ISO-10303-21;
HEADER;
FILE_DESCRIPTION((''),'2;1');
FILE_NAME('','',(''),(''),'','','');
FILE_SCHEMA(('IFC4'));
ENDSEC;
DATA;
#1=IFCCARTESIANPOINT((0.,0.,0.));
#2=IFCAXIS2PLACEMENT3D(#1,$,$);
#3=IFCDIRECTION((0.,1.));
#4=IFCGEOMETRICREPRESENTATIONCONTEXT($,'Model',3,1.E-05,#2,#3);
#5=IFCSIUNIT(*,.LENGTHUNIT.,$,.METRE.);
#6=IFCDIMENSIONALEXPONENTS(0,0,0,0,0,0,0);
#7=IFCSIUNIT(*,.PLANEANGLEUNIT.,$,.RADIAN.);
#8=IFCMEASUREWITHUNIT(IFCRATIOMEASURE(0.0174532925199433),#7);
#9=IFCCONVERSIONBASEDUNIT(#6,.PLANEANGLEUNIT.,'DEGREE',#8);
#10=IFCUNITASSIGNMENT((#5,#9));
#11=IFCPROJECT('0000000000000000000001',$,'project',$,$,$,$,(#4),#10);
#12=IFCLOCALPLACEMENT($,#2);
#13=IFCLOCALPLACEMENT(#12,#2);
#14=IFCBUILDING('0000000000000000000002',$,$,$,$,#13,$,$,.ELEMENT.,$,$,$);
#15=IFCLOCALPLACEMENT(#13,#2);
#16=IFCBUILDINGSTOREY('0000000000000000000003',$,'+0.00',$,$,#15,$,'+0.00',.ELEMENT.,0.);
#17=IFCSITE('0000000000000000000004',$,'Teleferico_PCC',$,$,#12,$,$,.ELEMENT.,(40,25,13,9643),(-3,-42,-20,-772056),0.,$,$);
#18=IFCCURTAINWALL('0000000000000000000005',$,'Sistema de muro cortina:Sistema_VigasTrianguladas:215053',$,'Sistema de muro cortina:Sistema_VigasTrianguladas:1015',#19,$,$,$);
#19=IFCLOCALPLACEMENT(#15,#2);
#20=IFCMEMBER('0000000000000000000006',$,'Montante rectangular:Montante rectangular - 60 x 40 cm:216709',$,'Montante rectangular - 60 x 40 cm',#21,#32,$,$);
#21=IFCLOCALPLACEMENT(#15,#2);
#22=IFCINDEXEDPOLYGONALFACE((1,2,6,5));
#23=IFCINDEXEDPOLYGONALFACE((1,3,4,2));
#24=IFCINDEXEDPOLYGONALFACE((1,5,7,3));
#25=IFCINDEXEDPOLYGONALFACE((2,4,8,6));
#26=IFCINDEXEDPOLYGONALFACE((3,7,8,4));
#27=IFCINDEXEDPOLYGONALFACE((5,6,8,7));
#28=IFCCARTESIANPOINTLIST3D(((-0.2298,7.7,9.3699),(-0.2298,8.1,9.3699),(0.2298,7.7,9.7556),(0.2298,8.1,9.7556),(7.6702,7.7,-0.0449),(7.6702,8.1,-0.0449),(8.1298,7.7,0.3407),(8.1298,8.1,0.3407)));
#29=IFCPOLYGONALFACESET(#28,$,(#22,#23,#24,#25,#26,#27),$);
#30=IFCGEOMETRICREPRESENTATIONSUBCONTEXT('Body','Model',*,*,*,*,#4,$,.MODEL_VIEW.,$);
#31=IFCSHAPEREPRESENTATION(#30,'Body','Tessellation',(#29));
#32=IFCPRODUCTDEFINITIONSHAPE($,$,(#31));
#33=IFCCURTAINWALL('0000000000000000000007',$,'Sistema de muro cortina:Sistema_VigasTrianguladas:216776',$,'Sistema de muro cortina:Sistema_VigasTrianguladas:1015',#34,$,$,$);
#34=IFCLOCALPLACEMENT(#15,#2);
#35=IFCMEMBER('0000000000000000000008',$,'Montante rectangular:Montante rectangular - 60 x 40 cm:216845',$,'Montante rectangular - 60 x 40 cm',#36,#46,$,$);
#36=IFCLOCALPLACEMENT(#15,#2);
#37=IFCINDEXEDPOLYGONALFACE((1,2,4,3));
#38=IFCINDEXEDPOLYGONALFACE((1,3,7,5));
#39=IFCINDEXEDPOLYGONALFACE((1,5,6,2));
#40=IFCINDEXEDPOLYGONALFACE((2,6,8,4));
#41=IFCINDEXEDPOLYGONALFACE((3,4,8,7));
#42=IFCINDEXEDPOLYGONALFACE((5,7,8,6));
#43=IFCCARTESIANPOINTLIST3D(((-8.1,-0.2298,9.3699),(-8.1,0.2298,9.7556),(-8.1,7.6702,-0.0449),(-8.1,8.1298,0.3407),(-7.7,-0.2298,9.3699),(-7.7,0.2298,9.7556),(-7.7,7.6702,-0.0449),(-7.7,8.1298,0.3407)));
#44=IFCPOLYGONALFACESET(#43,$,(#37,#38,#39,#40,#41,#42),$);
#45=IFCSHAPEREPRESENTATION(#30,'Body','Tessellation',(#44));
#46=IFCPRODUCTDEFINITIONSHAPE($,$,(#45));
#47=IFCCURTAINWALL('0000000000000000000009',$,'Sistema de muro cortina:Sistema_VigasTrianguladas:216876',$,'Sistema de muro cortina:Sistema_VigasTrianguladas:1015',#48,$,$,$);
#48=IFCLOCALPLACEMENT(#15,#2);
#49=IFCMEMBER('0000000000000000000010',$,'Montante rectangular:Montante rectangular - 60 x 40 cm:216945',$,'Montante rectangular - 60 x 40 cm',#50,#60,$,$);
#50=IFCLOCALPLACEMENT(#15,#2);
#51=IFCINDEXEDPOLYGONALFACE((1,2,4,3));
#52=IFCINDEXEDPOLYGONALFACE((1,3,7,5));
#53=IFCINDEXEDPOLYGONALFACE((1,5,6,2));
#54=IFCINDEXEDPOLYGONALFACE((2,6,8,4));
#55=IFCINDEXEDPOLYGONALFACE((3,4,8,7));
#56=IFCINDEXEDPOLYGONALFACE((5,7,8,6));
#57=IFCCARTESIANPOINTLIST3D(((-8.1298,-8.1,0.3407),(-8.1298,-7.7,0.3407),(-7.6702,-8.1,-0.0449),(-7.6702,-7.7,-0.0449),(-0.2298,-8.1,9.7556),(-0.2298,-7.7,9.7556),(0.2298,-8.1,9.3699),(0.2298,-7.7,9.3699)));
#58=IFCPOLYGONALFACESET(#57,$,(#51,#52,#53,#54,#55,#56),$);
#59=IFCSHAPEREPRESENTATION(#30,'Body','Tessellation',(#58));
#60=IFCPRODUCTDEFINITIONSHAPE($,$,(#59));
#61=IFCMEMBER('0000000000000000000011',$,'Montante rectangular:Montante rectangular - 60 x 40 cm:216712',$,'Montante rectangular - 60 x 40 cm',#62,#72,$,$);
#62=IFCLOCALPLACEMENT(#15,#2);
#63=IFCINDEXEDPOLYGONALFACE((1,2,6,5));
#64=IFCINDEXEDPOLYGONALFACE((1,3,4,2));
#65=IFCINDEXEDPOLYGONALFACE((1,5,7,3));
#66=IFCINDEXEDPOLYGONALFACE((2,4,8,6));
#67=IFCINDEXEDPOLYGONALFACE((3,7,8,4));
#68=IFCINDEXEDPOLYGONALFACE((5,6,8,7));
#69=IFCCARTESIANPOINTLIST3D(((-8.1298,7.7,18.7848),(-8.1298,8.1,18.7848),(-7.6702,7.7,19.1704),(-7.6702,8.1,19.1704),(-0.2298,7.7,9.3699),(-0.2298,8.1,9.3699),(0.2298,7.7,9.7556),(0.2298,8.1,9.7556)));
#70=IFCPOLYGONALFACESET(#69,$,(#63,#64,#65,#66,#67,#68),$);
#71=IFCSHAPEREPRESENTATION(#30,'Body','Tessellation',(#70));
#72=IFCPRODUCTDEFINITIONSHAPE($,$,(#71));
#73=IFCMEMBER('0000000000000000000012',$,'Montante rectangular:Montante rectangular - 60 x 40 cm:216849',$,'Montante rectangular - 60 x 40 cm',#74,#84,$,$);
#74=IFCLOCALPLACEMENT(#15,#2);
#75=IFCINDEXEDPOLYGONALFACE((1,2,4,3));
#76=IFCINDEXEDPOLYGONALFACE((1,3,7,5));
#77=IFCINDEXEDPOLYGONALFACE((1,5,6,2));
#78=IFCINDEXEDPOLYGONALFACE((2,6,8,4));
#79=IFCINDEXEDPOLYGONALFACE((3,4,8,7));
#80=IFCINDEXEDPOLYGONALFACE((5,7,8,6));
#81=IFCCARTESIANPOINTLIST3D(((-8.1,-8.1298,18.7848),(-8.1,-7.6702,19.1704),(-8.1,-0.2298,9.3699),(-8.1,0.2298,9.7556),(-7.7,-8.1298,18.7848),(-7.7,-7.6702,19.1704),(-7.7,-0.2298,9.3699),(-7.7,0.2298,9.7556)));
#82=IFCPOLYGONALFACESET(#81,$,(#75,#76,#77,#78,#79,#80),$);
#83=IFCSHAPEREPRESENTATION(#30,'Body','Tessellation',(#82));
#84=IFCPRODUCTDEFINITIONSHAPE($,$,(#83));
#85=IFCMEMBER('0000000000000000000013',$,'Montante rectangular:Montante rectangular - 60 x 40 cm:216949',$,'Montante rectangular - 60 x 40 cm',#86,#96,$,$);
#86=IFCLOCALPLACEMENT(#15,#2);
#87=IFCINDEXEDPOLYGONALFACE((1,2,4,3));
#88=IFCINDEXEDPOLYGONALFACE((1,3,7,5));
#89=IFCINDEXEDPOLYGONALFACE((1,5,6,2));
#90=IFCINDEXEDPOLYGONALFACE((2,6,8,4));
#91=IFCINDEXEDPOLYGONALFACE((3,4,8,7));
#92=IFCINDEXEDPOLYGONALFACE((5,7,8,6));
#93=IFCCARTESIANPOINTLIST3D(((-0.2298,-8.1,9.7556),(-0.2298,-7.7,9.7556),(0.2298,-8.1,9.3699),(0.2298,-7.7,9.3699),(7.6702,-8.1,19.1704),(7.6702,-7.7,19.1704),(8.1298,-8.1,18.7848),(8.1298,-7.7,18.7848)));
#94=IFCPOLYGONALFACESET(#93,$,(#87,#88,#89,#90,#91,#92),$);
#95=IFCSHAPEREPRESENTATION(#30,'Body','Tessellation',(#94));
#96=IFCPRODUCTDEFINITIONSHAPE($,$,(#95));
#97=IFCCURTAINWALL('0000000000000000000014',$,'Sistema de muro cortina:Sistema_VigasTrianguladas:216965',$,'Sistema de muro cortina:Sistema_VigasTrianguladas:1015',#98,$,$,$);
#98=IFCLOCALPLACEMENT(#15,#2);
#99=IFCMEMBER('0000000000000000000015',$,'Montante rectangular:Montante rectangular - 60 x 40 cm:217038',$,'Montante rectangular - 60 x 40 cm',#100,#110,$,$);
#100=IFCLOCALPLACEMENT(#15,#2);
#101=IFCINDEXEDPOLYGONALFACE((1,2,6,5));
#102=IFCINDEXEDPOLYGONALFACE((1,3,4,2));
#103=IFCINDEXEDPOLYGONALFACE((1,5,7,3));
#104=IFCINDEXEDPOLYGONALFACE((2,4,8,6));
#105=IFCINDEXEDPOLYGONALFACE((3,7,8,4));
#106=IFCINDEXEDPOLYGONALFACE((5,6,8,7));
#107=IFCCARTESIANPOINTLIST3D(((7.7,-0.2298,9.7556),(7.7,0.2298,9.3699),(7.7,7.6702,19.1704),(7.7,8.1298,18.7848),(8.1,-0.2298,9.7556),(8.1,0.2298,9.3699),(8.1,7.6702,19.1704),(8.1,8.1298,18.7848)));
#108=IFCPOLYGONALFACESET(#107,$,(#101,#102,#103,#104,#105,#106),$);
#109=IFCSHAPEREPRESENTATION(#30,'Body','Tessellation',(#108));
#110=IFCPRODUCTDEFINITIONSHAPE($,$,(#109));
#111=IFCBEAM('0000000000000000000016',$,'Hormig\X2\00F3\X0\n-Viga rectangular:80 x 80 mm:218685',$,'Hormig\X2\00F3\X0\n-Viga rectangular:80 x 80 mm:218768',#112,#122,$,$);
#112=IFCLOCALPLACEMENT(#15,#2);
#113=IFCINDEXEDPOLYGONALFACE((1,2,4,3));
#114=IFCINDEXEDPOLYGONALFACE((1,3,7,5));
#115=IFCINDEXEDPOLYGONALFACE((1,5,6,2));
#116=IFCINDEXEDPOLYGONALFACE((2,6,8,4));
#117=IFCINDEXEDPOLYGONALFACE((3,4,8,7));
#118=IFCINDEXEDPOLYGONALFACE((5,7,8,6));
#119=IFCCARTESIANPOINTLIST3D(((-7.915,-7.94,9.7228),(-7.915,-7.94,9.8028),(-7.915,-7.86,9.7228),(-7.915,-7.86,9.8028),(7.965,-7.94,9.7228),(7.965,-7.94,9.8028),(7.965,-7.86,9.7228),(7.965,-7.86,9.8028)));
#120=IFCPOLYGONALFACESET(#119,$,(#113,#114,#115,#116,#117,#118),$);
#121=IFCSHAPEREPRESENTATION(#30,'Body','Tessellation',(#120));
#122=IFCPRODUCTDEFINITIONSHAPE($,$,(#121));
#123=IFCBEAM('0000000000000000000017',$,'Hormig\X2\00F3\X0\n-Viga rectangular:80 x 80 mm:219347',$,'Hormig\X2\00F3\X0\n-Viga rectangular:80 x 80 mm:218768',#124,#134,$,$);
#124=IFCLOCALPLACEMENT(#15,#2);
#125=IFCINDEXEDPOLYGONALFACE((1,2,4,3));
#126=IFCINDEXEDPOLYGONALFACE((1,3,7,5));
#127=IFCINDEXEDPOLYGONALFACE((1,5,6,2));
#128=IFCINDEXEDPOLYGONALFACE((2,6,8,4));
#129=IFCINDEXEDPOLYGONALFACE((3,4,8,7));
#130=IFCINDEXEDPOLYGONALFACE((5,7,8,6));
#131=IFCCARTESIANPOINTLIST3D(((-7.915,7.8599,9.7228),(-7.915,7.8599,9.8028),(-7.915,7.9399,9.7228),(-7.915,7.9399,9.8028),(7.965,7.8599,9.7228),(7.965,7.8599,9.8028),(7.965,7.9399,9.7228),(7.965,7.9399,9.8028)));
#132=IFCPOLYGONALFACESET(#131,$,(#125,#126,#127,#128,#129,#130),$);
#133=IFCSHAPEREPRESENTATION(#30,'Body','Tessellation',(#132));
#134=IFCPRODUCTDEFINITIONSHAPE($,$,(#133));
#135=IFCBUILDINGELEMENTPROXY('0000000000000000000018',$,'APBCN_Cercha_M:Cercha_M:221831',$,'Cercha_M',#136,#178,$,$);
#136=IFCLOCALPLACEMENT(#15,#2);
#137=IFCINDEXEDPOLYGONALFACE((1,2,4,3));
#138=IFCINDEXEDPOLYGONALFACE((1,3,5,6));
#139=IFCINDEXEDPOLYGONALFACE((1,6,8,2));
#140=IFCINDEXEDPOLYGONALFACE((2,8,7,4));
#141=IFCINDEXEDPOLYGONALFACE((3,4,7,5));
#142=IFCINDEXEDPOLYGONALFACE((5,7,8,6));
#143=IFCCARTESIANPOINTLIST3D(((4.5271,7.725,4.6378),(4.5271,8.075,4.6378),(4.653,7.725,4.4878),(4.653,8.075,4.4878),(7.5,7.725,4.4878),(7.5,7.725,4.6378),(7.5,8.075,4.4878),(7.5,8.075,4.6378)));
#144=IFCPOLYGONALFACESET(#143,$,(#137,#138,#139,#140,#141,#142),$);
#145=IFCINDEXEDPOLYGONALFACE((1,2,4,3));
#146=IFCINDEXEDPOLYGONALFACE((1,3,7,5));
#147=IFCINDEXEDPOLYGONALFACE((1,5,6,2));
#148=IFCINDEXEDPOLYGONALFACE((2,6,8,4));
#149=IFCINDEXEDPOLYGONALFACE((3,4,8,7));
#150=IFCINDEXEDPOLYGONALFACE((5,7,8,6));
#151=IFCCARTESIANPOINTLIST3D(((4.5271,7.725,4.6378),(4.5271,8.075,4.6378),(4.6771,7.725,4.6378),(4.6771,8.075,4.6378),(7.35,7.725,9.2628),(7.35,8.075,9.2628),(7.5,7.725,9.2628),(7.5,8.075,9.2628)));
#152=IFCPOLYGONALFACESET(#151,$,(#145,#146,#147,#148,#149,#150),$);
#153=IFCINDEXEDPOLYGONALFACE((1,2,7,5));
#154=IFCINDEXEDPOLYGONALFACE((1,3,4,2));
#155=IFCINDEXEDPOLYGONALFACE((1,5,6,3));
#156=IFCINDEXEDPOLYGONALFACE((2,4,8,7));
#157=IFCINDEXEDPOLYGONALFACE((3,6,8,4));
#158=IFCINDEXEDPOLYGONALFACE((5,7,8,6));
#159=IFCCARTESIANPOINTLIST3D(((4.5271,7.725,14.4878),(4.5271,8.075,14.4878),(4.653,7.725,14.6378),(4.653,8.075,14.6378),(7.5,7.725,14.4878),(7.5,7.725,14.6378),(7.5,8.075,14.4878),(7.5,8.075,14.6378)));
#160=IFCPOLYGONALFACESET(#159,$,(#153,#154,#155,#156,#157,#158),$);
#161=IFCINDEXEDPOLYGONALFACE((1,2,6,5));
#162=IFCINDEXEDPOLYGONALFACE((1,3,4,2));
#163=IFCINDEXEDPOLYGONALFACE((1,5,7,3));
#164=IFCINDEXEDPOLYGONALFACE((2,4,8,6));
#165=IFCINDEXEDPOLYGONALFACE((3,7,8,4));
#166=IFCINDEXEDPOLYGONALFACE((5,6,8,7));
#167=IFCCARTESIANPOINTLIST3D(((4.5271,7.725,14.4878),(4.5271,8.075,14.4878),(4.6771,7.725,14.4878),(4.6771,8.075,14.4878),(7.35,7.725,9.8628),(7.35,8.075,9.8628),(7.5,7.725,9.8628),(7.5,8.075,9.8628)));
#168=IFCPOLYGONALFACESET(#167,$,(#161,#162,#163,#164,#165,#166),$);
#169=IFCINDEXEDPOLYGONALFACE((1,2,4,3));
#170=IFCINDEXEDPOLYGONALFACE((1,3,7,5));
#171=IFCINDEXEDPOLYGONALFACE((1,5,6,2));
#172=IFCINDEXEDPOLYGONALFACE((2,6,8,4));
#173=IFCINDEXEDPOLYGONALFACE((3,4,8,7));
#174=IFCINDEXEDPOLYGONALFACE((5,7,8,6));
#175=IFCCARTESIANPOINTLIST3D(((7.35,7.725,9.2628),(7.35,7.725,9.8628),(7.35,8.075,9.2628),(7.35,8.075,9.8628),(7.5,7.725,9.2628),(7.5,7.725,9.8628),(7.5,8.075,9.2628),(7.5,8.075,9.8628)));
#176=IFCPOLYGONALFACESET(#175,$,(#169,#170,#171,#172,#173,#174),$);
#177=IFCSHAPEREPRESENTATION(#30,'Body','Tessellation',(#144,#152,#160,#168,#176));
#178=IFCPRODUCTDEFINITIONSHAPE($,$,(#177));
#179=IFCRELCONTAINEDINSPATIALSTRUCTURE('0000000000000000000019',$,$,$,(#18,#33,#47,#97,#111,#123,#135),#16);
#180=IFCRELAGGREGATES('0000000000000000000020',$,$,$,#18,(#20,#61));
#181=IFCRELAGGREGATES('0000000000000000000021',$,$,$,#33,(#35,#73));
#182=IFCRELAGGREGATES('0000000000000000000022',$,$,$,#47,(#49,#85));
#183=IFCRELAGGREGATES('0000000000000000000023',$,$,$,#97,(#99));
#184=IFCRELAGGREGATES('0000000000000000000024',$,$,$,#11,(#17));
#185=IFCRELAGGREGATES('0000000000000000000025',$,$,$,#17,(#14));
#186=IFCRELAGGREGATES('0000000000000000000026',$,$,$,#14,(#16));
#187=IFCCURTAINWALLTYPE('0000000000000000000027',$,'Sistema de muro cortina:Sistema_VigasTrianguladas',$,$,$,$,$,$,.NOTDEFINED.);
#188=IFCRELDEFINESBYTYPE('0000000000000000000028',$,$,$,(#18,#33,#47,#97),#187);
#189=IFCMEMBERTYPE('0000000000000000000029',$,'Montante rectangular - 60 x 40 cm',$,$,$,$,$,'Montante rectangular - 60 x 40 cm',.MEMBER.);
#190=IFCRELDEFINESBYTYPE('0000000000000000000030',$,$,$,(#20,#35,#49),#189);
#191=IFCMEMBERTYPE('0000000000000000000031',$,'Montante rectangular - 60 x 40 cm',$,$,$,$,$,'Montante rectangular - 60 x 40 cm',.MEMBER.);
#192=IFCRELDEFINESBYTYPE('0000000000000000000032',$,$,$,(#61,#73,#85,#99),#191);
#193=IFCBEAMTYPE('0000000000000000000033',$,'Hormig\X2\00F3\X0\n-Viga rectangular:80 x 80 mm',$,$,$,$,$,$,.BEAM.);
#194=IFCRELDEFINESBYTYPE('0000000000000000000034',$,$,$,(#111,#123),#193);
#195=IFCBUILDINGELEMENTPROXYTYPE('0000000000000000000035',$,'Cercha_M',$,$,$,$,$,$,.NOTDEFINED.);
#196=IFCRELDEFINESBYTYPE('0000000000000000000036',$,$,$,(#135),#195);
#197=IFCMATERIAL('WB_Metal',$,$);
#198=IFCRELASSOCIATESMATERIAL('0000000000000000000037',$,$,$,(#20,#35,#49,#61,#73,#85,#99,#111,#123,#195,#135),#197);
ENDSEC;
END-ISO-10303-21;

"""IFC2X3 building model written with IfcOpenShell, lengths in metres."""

from ifc_helpers import new_model, entity, si_unit, converted_unit, direction, frame, frame_2d, origin, origin_2d_with_axis, place, context, subcontext, project, spatial, polyline, rectangle, outline, extrude, source, transform, mapped, material, type_object, type_shapes, element, aggregate, save


model = new_model("IFC2X3")

# Units and contexts
model_context = context("Model", 3, precision=1e-05, world=origin(), true_north=direction((0.0, 1.0)))
body_context = subcontext(model_context, "Body", "Model", "MODEL_VIEW")
ifc_project = project(units=[si_unit("LENGTHUNIT", "METRE"), converted_unit("PLANEANGLEUNIT", "DEGREE", entity("IfcRatioMeasure", 0.0174532925199433), si_unit("PLANEANGLEUNIT", "RADIAN"), dimensions=[0, 0, 0, 0, 0, 0, 0])], contexts=[model_context])

# Site, building, storey
site_placement = place(None, origin())
site = spatial("IfcSite", under=ifc_project, at=site_placement, Name="Teleferico_PCC", CompositionType="ELEMENT", RefLatitude=(40, 25, 13, 9643), RefLongitude=(-3, -42, -20, -772056), RefElevation=0.0)
building_placement = place(site_placement, origin())
building = spatial("IfcBuilding", under=site, at=building_placement, CompositionType="ELEMENT")
storey_placement = place(building_placement, origin())
storey = spatial("IfcBuildingStorey", under=building, at=storey_placement, Name="+0.00", LongName="+0.00", CompositionType="ELEMENT", Elevation=0.0)

# Curtain walls, members
curtain_wall_type = type_object("IfcCurtainWallType", Name="Sistema de muro cortina:Sistema_VigasTrianguladas", PredefinedType="NOTDEFINED")
curtain_wall_1_placement = place(storey_placement, origin())
curtain_wall_1 = element("IfcCurtainWall", 1, at=curtain_wall_1_placement, inside=storey, type_object=curtain_wall_type, Name="Sistema de muro cortina:Sistema_VigasTrianguladas:215053", ObjectType="Sistema de muro cortina:Sistema_VigasTrianguladas:1015")
ifc_material = material(Name="WB_Metal")
member_type_1 = type_object("IfcMemberType", Name="Montante rectangular - 60 x 40 cm", ElementType="Montante rectangular - 60 x 40 cm", PredefinedType="MEMBER")
shared_shape_1 = source(origin(), body_context, "Body", "SweptSolid", [
    extrude(rectangle(XDim=0.4, YDim=0.6, at=frame_2d((0.0, 0.0), x_axis=(1.0, 0.0))), frame((0.0, 0.0, -12.2902), z_axis=(0.0, 0.0, 1.0), x_axis=(0.0, -1.0, 0.0)), (0.0, 0.0, 1.0), 12.2902),
])
type_shapes(member_type_1, [shared_shape_1])
member_1_placement = place(storey_placement, frame((0.0, 7.9, 9.5628), z_axis=(-0.642788, 0.0, 0.766044), x_axis=(0.766044, 0.0, 0.642788)))
member_1 = element("IfcMember", 2, at=member_1_placement, type_object=member_type_1, material=ifc_material, Name="Montante rectangular:Montante rectangular - 60 x 40 cm:216709", ObjectType="Montante rectangular - 60 x 40 cm", context=body_context, shape_type="MappedRepresentation", body=[
    mapped(shared_shape_1, transform((0.0, 0.0, 0.0), scale=1.0)),
])
curtain_wall_2_placement = place(storey_placement, origin())
curtain_wall_2 = element("IfcCurtainWall", 3, at=curtain_wall_2_placement, inside=storey, type_object=curtain_wall_type, Name="Sistema de muro cortina:Sistema_VigasTrianguladas:216776", ObjectType="Sistema de muro cortina:Sistema_VigasTrianguladas:1015")
member_2_placement = place(storey_placement, frame((-7.9, 0.0, 9.5628), z_axis=(0.0, -0.642788, 0.766044), x_axis=(0.0, 0.766044, 0.642788)))
member_2 = element("IfcMember", 4, at=member_2_placement, type_object=member_type_1, material=ifc_material, Name="Montante rectangular:Montante rectangular - 60 x 40 cm:216845", ObjectType="Montante rectangular - 60 x 40 cm", context=body_context, shape_type="MappedRepresentation", body=[
    mapped(shared_shape_1, transform((0.0, 0.0, 0.0), scale=1.0)),
])
curtain_wall_3_placement = place(storey_placement, origin())
curtain_wall_3 = element("IfcCurtainWall", 5, at=curtain_wall_3_placement, inside=storey, type_object=curtain_wall_type, Name="Sistema de muro cortina:Sistema_VigasTrianguladas:216876", ObjectType="Sistema de muro cortina:Sistema_VigasTrianguladas:1015")
member_3_placement = place(storey_placement, frame((0.0, -7.9, 9.5628), z_axis=(0.642788, 0.0, 0.766044), x_axis=(-0.766044, 0.0, 0.642788)))
member_3 = element("IfcMember", 6, at=member_3_placement, type_object=member_type_1, material=ifc_material, Name="Montante rectangular:Montante rectangular - 60 x 40 cm:216945", ObjectType="Montante rectangular - 60 x 40 cm", context=body_context, shape_type="MappedRepresentation", body=[
    mapped(shared_shape_1, transform((0.0, 0.0, 0.0), scale=1.0)),
])

# Members
member_type_2 = type_object("IfcMemberType", Name="Montante rectangular - 60 x 40 cm", ElementType="Montante rectangular - 60 x 40 cm", PredefinedType="MEMBER")
shared_shape_2 = source(origin(), body_context, "Body", "SweptSolid", [
    extrude(rectangle(XDim=0.4, YDim=0.6, at=origin_2d_with_axis()), frame((0.0, 0.0, -12.2902), z_axis=(0.0, 0.0, 1.0), x_axis=(0.0, -1.0, 0.0)), (0.0, 0.0, 1.0), 12.2902),
])
type_shapes(member_type_2, [shared_shape_2])
member_4_placement = place(storey_placement, frame((-7.9, 7.9, 18.9776), z_axis=(-0.642788, 0.0, 0.766044), x_axis=(0.766044, 0.0, 0.642788)))
member_4 = element("IfcMember", 7, at=member_4_placement, type_object=member_type_2, material=ifc_material, Name="Montante rectangular:Montante rectangular - 60 x 40 cm:216712", ObjectType="Montante rectangular - 60 x 40 cm", context=body_context, shape_type="MappedRepresentation", body=[
    mapped(shared_shape_2, transform((0.0, 0.0, 0.0), scale=1.0)),
])
member_5_placement = place(storey_placement, frame((-7.9, -7.9, 18.9776), z_axis=(0.0, -0.642788, 0.766044), x_axis=(0.0, 0.766044, 0.642788)))
member_5 = element("IfcMember", 8, at=member_5_placement, type_object=member_type_2, material=ifc_material, Name="Montante rectangular:Montante rectangular - 60 x 40 cm:216849", ObjectType="Montante rectangular - 60 x 40 cm", context=body_context, shape_type="MappedRepresentation", body=[
    mapped(shared_shape_2, transform((0.0, 0.0, 0.0), scale=1.0)),
])
member_6_placement = place(storey_placement, frame((7.9, -7.9, 18.9776), z_axis=(0.642788, 0.0, 0.766044), x_axis=(-0.766044, 0.0, 0.642788)))
member_6 = element("IfcMember", 9, at=member_6_placement, type_object=member_type_2, material=ifc_material, Name="Montante rectangular:Montante rectangular - 60 x 40 cm:216949", ObjectType="Montante rectangular - 60 x 40 cm", context=body_context, shape_type="MappedRepresentation", body=[
    mapped(shared_shape_2, transform((0.0, 0.0, 0.0), scale=1.0)),
])

# Curtain wall, member
curtain_wall_4_placement = place(storey_placement, origin())
curtain_wall_4 = element("IfcCurtainWall", 10, at=curtain_wall_4_placement, inside=storey, type_object=curtain_wall_type, Name="Sistema de muro cortina:Sistema_VigasTrianguladas:216965", ObjectType="Sistema de muro cortina:Sistema_VigasTrianguladas:1015")
member_7_placement = place(storey_placement, frame((7.9, 7.9, 18.9776), z_axis=(0.0, 0.642788, 0.766044), x_axis=(0.0, -0.766044, 0.642788)))
member_7 = element("IfcMember", 11, at=member_7_placement, type_object=member_type_2, material=ifc_material, Name="Montante rectangular:Montante rectangular - 60 x 40 cm:217038", ObjectType="Montante rectangular - 60 x 40 cm", context=body_context, shape_type="MappedRepresentation", body=[
    mapped(shared_shape_2, transform((0.0, 0.0, 0.0), scale=1.0)),
])

aggregate(curtain_wall_1, [member_1, member_4])
aggregate(curtain_wall_2, [member_2, member_5])
aggregate(curtain_wall_3, [member_3, member_6])
aggregate(curtain_wall_4, [member_7])

# Beams
beam_type = type_object("IfcBeamType", Name="Hormigón-Viga rectangular:80 x 80 mm", PredefinedType="BEAM")
beam_1_placement = place(storey_placement, frame((-7.875, -7.9, 9.7628)))
element("IfcBeam", 12, at=beam_1_placement, inside=storey, type_object=beam_type, material=ifc_material, Name="Hormigón-Viga rectangular:80 x 80 mm:218685", ObjectType="Hormigón-Viga rectangular:80 x 80 mm:218768", context=body_context, shape_type="SweptSolid", body=[
    extrude(rectangle(XDim=0.08, YDim=0.08, at=frame_2d((0.0, 0.0), x_axis=(1.0, 0.0))), frame((-0.04, 0.0, 0.0), z_axis=(1.0, 0.0, 0.0), x_axis=(0.0, 0.0, -1.0)), (0.0, 0.0, 1.0), 15.88),
])
beam_2_placement = place(storey_placement, frame((-7.875, 7.8999, 9.7628)))
element("IfcBeam", 13, at=beam_2_placement, inside=storey, type_object=beam_type, material=ifc_material, Name="Hormigón-Viga rectangular:80 x 80 mm:219347", ObjectType="Hormigón-Viga rectangular:80 x 80 mm:218768", context=body_context, shape_type="SweptSolid", body=[
    extrude(rectangle(XDim=0.08, YDim=0.08, at=frame_2d((0.0, 0.0), x_axis=(1.0, 0.0))), frame((-0.04, 0.0, 0.0), z_axis=(1.0, 0.0, 0.0), x_axis=(0.0, 0.0, -1.0)), (0.0, 0.0, 1.0), 15.88),
])

# Building element proxy
building_element_proxy_type_1 = type_object("IfcBuildingElementProxyType", Name="Cercha_M", PredefinedType="NOTDEFINED", material=ifc_material)
shared_shape_3 = source(origin(), body_context, "Body", "SweptSolid", [
    extrude(outline(polyline([(-1.455, -0.075), (1.3921, -0.075), (1.5179, 0.075), (-1.455, 0.075), (-1.455, -0.075)])), frame((-1.455, -0.175, -5.0), z_axis=(0.0, 1.0, 0.0), x_axis=(-1.0, 0.0, 0.0)), (0.0, 0.0, 1.0), 0.35),
    extrude(outline(polyline([(1.3365, -2.3125), (1.4865, -2.3125), (-1.3365, 2.3125), (-1.4865, 2.3125), (1.3365, -2.3125)])), frame((-1.4865, -0.175, -2.6125), z_axis=(0.0, 1.0, 0.0), x_axis=(1.0, 0.0, 0.0)), (0.0, 0.0, 1.0), 0.35),
    extrude(outline(polyline([(-1.455, -0.075), (1.5179, -0.075), (1.3921, 0.075), (-1.455, 0.075), (-1.455, -0.075)])), frame((-1.455, -0.175, 5.0), z_axis=(0.0, 1.0, 0.0), x_axis=(-1.0, 0.0, 0.0)), (0.0, 0.0, 1.0), 0.35),
    extrude(outline(polyline([(-2.6701, -0.064), (2.7483, -0.064), (2.6701, 0.064), (-2.7483, 0.064), (-2.6701, -0.064)])), frame((-1.4865, -0.175, 2.6125), z_axis=(0.0, 1.0, 0.0), x_axis=(-0.520985, 0.0, 0.853566)), (0.0, 0.0, 1.0), 0.35),
    extrude(rectangle(XDim=0.35, YDim=0.15, at=origin_2d_with_axis()), frame((-0.075, 0.0, -0.3), z_axis=(0.0, 0.0, 1.0), x_axis=(0.0, 1.0, 0.0)), (0.0, 0.0, 1.0), 0.6),
])
type_shapes(building_element_proxy_type_1, [shared_shape_3])
for number, where, name in (
    (14, (7.5, 7.9, 9.5628), "APBCN_Cercha_M:Cercha_M:221831"),
):
    element("IfcBuildingElementProxy", number, at=place(storey_placement, frame(where)), inside=storey, type_object=building_element_proxy_type_1, material=ifc_material, Name=name, ObjectType="Cercha_M", context=body_context, shape_type="MappedRepresentation", body=[
        mapped(shared_shape_3, transform((0.0, 0.0, 0.0), scale=1.0)),
    ])

save(model, "model.ifc")
